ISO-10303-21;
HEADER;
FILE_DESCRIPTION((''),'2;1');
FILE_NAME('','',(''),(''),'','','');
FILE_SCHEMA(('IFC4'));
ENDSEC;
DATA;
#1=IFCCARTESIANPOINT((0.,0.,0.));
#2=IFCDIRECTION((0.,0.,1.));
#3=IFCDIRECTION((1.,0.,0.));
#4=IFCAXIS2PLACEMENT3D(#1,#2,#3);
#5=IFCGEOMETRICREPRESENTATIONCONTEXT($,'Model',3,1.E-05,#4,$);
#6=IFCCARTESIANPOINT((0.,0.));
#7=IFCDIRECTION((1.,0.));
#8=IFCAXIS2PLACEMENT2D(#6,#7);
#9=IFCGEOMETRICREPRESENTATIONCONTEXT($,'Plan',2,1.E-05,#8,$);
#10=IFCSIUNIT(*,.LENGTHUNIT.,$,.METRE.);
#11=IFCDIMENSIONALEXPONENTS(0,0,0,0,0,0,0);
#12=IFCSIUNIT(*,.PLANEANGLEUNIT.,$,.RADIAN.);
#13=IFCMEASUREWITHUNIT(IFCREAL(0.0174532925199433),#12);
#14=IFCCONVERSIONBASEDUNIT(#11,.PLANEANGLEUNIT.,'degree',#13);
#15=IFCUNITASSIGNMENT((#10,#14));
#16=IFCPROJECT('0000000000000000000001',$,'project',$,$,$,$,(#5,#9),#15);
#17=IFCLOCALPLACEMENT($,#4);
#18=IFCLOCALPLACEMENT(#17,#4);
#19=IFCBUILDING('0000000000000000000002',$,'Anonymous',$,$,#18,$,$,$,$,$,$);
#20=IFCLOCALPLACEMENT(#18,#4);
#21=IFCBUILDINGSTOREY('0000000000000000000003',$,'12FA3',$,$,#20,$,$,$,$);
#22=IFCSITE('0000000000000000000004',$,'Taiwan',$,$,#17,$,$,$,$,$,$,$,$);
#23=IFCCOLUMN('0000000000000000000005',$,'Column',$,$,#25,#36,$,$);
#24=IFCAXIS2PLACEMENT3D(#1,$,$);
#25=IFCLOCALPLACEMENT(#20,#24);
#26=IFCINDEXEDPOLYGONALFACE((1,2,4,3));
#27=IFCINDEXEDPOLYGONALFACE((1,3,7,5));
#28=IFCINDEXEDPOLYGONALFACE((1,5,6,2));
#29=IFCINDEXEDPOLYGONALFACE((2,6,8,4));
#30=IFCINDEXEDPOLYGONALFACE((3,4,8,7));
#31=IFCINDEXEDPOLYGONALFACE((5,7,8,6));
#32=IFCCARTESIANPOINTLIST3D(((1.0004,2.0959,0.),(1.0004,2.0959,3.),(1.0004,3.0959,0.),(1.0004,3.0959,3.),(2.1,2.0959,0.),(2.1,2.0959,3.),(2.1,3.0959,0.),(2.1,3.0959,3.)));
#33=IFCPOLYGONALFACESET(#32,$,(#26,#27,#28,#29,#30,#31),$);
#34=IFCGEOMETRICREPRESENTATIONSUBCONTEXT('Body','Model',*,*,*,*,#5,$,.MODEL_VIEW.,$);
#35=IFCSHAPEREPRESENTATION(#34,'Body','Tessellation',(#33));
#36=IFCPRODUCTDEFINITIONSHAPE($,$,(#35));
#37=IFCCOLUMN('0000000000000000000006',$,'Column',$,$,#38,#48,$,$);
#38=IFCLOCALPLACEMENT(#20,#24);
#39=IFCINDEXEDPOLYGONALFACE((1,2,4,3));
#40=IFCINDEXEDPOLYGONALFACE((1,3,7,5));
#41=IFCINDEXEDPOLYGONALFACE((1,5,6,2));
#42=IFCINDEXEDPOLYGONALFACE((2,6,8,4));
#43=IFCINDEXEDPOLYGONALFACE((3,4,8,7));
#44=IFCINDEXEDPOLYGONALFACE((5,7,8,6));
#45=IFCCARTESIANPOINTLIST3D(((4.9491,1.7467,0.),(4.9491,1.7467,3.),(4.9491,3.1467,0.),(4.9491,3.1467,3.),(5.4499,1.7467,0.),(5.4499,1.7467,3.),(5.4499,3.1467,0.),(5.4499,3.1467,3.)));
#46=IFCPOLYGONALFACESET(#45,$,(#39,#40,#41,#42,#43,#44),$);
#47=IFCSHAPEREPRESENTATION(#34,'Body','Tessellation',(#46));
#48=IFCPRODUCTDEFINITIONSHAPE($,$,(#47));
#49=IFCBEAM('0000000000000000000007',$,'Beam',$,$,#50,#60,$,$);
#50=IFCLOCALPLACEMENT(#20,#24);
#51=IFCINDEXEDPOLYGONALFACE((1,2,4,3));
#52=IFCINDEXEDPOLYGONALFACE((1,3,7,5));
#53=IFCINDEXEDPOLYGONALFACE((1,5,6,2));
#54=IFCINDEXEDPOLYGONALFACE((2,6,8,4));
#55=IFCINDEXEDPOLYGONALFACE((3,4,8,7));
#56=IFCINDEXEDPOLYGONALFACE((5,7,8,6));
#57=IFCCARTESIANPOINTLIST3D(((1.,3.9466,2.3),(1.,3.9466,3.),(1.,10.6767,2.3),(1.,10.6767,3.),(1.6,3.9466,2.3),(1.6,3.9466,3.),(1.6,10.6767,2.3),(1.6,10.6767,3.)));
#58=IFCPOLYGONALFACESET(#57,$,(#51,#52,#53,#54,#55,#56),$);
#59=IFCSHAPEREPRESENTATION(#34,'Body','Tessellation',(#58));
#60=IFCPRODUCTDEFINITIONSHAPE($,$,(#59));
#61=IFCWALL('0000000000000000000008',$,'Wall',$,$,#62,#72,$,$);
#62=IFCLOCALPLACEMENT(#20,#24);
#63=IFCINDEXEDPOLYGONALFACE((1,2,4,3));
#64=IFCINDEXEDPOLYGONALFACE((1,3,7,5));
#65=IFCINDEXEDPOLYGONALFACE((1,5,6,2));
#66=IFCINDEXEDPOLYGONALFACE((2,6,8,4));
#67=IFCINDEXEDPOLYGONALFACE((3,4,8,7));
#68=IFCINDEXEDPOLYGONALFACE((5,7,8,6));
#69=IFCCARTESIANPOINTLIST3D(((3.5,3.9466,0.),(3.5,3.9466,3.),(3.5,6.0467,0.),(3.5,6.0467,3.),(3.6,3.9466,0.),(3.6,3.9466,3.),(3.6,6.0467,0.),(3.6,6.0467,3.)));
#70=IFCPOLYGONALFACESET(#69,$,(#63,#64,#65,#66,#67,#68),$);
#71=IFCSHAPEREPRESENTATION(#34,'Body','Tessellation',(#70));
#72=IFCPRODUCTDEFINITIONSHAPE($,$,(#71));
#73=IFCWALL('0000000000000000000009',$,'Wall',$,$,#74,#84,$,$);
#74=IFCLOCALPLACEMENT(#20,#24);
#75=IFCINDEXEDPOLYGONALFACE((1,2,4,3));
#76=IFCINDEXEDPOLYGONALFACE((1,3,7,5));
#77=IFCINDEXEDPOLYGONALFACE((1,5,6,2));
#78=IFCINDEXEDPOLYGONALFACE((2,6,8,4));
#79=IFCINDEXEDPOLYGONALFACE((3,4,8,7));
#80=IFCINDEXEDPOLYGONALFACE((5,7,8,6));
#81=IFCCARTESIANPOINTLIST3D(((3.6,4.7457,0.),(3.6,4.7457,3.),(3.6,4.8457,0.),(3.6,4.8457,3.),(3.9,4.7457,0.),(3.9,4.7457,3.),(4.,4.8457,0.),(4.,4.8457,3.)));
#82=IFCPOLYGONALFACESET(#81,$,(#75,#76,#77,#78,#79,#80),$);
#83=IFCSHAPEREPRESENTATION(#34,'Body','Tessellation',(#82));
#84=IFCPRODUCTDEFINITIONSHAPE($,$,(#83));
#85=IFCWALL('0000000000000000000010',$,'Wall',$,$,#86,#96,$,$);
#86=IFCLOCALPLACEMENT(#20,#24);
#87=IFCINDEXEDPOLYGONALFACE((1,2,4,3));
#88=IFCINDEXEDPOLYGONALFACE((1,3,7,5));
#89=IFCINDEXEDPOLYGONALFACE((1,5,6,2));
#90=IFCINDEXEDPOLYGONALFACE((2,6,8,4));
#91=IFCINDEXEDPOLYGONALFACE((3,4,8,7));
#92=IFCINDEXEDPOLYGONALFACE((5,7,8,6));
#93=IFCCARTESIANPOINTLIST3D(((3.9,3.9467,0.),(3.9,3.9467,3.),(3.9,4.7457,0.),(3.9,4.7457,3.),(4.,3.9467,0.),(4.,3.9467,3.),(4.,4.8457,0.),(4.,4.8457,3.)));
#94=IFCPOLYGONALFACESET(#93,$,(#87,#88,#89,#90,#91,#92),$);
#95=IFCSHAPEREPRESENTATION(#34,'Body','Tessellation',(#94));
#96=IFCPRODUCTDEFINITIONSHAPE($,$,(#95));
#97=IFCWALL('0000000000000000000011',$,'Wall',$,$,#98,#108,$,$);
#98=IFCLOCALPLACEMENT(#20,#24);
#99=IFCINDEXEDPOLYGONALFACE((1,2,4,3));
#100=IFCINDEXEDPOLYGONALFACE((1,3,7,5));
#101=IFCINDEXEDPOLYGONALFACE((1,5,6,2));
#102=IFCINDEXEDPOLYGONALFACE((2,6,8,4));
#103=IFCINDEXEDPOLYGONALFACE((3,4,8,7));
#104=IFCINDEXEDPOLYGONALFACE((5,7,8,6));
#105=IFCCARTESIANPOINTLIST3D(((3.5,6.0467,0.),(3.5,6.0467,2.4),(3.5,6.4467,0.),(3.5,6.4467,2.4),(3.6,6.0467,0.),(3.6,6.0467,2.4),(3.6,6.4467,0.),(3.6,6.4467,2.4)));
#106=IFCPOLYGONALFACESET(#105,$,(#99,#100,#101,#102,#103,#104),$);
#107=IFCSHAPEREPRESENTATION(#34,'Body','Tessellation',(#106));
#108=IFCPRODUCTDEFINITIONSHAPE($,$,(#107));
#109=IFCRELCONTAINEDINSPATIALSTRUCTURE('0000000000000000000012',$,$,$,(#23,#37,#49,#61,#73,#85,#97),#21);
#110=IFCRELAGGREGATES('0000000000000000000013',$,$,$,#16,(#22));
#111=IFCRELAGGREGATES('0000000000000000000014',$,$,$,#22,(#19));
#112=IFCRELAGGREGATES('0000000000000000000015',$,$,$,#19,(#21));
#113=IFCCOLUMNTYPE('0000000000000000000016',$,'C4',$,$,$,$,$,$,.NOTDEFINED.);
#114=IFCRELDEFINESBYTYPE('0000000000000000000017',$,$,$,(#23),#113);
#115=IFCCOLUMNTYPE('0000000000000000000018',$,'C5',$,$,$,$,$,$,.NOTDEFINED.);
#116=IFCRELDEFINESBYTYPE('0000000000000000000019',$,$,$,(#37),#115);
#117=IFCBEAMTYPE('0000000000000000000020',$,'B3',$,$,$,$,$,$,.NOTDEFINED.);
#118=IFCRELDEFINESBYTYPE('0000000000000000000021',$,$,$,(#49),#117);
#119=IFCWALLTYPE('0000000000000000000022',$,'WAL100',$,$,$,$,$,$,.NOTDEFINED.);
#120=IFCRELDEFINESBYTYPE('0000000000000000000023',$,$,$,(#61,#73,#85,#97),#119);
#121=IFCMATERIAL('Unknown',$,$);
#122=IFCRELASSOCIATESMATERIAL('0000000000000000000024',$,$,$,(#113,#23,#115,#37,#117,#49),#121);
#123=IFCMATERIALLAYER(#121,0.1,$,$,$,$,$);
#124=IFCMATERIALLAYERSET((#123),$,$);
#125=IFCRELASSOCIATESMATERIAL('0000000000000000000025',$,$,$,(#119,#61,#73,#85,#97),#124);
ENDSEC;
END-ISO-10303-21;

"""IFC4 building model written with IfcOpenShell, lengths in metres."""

from ifc_helpers import new_model, entity, si_unit, converted_unit, frame, origin_with_axes, origin_2d_with_axis, place, context, subcontext, project, spatial, line, indexed_curve, rectangle, outline, extrude, material, layer, layer_set, layer_usage, material_profile, profile_set, profile_usage, type_object, element, save


model = new_model("IFC4")

# Units and contexts
model_context = context("Model", 3, precision=1e-05, world=origin_with_axes())
plan_context = context("Plan", 2, precision=1e-05, world=origin_2d_with_axis())
body_context_1 = subcontext(model_context, "Body", "Model", "MODEL_VIEW")
ifc_project = project(units=[si_unit("LENGTHUNIT", "METRE"), converted_unit("PLANEANGLEUNIT", "degree", entity("IfcReal", 0.0174532925199433), si_unit("PLANEANGLEUNIT", "RADIAN"), dimensions=[0, 0, 0, 0, 0, 0, 0])], contexts=[model_context, plan_context])

# Site, building, storey
site_placement = place(None, origin_with_axes())
site = spatial("IfcSite", under=ifc_project, at=site_placement, Name="Taiwan")
building_placement = place(site_placement, origin_with_axes())
building = spatial("IfcBuilding", under=site, at=building_placement, Name="Anonymous")
storey_placement = place(building_placement, origin_with_axes())
storey = spatial("IfcBuildingStorey", under=building, at=storey_placement, Name="12FA3")

# Columns
ifc_material = material(Name="Unknown")
ifc_material_profile_1 = material_profile(ifc_material, outline(indexed_curve([(0.0, 1.0), (1.0995, 1.0), (1.0995, 0.0), (0.0, 0.0), (0.0, 1.0)])))
ifc_profile_set_1 = profile_set([ifc_material_profile_1])
ifc_profile_usage_1 = profile_usage(ifc_profile_set_1, cardinal=5)
column_type_1 = type_object("IfcColumnType", Name="C4", PredefinedType="NOTDEFINED", material=ifc_profile_set_1)
column_1_placement = place(storey_placement, frame((1.0004, 2.0959, 0.0), z_axis=(0.0, 0.0, 1.0), x_axis=(1.0, 0.0, 0.0)))
element("IfcColumn", 1, at=column_1_placement, inside=storey, type_object=column_type_1, material=ifc_profile_usage_1, Name="Column", context=body_context_1, shape_type="SweptSolid", body=[
    extrude(outline(indexed_curve([(0.0, 1.0), (1.0995, 1.0), (1.0995, 0.0), (0.0, 0.0), (0.0, 1.0)])), origin_with_axes(), (0.0, 0.0, 1.0), 3.0),
])
ifc_material_profile_2 = material_profile(ifc_material, outline(indexed_curve([(0.0, 0.0), (0.5008, 0.0), (0.5008, 1.4), (0.0, 1.4), (0.0, 0.0)])))
ifc_profile_set_2 = profile_set([ifc_material_profile_2])
ifc_profile_usage_2 = profile_usage(ifc_profile_set_2, cardinal=5)
column_type_2 = type_object("IfcColumnType", Name="C5", PredefinedType="NOTDEFINED", material=ifc_profile_set_2)
column_2_placement = place(storey_placement, frame((4.9491, 1.7467, 0.0), z_axis=(0.0, 0.0, 1.0), x_axis=(1.0, 0.0, 0.0)))
element("IfcColumn", 2, at=column_2_placement, inside=storey, type_object=column_type_2, material=ifc_profile_usage_2, Name="Column", context=body_context_1, shape_type="SweptSolid", body=[
    extrude(outline(indexed_curve([(0.0, 0.0), (0.5008, 0.0), (0.5008, 1.4), (0.0, 1.4), (0.0, 0.0)])), origin_with_axes(), (0.0, 0.0, 1.0), 3.0),
])

# Beam
ifc_material_profile_3 = material_profile(ifc_material, rectangle(XDim=0.6, YDim=0.7, kind="CURVE"))
ifc_profile_set_3 = profile_set([ifc_material_profile_3])
ifc_profile_usage_3 = profile_usage(ifc_profile_set_3, cardinal=7)
beam_type = type_object("IfcBeamType", Name="B3", PredefinedType="NOTDEFINED", material=ifc_profile_set_3)
beam_placement = place(storey_placement, frame((1.0, 3.9466, 3.0), z_axis=(0.0, 1.0, 0.0), x_axis=(-1.0, 0.0, 0.0)))
element("IfcBeam", 3, at=beam_placement, inside=storey, type_object=beam_type, material=ifc_profile_usage_3, Name="Beam", context=body_context_1, shape_type="SweptSolid", body=[
    extrude(rectangle(XDim=0.6, YDim=0.7, kind="CURVE"), frame((-0.3, -0.35, 0.0), z_axis=(0.0, 0.0, 1.0), x_axis=(1.0, 0.0, 0.0)), (0.0, 0.0, 1.0), 6.7301),
])

# Walls
ifc_layer_1 = layer(ifc_material, 0.1)
ifc_layer_set_1 = layer_set([ifc_layer_1])
ifc_layer_usage_1 = layer_usage(ifc_layer_set_1, "AXIS2", "POSITIVE", 0.0)
wall_type_1 = type_object("IfcWallType", Name="WAL100", PredefinedType="NOTDEFINED", material=ifc_layer_set_1)
wall_1_placement = place(storey_placement, frame((3.6, 3.9466, 0.0), z_axis=(0.0, 0.0, 1.0), x_axis=(0.0, 1.0, 0.0)))
element("IfcWall", 4, at=wall_1_placement, inside=storey, type_object=wall_type_1, material=ifc_layer_usage_1, Name="Wall", context=body_context_1, shape_type="SweptSolid", body=[
    extrude(outline(indexed_curve([(0.0, 0.0), (0.0, 0.1), (2.1001, 0.1), (2.1001, 0.0)], segments=[line(1, 2, 3, 4, 1)])), origin_with_axes(), (0.0, 0.0, 1.0), 3.0),
])
ifc_layer_usage_2 = layer_usage(ifc_layer_set_1, "AXIS2", "POSITIVE", 0.0)
wall_2_placement = place(storey_placement, frame((3.6, 4.7457, 0.0), z_axis=(0.0, 0.0, 1.0), x_axis=(1.0, 0.0, 0.0)))
element("IfcWall", 5, at=wall_2_placement, inside=storey, type_object=wall_type_1, material=ifc_layer_usage_2, Name="Wall", context=body_context_1, shape_type="SweptSolid", body=[
    extrude(outline(indexed_curve([(0.0, 0.0), (0.0, 0.1), (0.4, 0.1), (0.3, 0.0)], segments=[line(1, 2, 3, 4, 1)])), origin_with_axes(), (0.0, 0.0, 1.0), 3.0),
])
ifc_layer_usage_3 = layer_usage(ifc_layer_set_1, "AXIS2", "POSITIVE", 0.0)
wall_3_placement = place(storey_placement, frame((3.9, 4.7457, 0.0), z_axis=(0.0, 0.0, 1.0), x_axis=(0.0, -1.0, 0.0)))
element("IfcWall", 6, at=wall_3_placement, inside=storey, type_object=wall_type_1, material=ifc_layer_usage_3, Name="Wall", context=body_context_1, shape_type="SweptSolid", body=[
    extrude(outline(indexed_curve([(0.0, 0.0), (-0.1, 0.1), (0.799, 0.1), (0.799, 0.0)], segments=[line(1, 2, 3, 4, 1)])), origin_with_axes(), (0.0, 0.0, 1.0), 3.0),
])
ifc_layer_usage_4 = layer_usage(ifc_layer_set_1, "AXIS2", "POSITIVE", 0.0)
wall_4_placement = place(storey_placement, frame((3.6, 6.0467, 0.0), z_axis=(0.0, 0.0, 1.0), x_axis=(0.0, 1.0, 0.0)))
element("IfcWall", 7, at=wall_4_placement, inside=storey, type_object=wall_type_1, material=ifc_layer_usage_4, Name="Wall", context=body_context_1, shape_type="SweptSolid", body=[
    extrude(outline(indexed_curve([(0.0, 0.0), (0.0, 0.1), (0.4, 0.1), (0.4, 0.0)], segments=[line(1, 2, 3, 4, 1)])), origin_with_axes(), (0.0, 0.0, 1.0), 2.4),
])

save(model, "model.ifc")
